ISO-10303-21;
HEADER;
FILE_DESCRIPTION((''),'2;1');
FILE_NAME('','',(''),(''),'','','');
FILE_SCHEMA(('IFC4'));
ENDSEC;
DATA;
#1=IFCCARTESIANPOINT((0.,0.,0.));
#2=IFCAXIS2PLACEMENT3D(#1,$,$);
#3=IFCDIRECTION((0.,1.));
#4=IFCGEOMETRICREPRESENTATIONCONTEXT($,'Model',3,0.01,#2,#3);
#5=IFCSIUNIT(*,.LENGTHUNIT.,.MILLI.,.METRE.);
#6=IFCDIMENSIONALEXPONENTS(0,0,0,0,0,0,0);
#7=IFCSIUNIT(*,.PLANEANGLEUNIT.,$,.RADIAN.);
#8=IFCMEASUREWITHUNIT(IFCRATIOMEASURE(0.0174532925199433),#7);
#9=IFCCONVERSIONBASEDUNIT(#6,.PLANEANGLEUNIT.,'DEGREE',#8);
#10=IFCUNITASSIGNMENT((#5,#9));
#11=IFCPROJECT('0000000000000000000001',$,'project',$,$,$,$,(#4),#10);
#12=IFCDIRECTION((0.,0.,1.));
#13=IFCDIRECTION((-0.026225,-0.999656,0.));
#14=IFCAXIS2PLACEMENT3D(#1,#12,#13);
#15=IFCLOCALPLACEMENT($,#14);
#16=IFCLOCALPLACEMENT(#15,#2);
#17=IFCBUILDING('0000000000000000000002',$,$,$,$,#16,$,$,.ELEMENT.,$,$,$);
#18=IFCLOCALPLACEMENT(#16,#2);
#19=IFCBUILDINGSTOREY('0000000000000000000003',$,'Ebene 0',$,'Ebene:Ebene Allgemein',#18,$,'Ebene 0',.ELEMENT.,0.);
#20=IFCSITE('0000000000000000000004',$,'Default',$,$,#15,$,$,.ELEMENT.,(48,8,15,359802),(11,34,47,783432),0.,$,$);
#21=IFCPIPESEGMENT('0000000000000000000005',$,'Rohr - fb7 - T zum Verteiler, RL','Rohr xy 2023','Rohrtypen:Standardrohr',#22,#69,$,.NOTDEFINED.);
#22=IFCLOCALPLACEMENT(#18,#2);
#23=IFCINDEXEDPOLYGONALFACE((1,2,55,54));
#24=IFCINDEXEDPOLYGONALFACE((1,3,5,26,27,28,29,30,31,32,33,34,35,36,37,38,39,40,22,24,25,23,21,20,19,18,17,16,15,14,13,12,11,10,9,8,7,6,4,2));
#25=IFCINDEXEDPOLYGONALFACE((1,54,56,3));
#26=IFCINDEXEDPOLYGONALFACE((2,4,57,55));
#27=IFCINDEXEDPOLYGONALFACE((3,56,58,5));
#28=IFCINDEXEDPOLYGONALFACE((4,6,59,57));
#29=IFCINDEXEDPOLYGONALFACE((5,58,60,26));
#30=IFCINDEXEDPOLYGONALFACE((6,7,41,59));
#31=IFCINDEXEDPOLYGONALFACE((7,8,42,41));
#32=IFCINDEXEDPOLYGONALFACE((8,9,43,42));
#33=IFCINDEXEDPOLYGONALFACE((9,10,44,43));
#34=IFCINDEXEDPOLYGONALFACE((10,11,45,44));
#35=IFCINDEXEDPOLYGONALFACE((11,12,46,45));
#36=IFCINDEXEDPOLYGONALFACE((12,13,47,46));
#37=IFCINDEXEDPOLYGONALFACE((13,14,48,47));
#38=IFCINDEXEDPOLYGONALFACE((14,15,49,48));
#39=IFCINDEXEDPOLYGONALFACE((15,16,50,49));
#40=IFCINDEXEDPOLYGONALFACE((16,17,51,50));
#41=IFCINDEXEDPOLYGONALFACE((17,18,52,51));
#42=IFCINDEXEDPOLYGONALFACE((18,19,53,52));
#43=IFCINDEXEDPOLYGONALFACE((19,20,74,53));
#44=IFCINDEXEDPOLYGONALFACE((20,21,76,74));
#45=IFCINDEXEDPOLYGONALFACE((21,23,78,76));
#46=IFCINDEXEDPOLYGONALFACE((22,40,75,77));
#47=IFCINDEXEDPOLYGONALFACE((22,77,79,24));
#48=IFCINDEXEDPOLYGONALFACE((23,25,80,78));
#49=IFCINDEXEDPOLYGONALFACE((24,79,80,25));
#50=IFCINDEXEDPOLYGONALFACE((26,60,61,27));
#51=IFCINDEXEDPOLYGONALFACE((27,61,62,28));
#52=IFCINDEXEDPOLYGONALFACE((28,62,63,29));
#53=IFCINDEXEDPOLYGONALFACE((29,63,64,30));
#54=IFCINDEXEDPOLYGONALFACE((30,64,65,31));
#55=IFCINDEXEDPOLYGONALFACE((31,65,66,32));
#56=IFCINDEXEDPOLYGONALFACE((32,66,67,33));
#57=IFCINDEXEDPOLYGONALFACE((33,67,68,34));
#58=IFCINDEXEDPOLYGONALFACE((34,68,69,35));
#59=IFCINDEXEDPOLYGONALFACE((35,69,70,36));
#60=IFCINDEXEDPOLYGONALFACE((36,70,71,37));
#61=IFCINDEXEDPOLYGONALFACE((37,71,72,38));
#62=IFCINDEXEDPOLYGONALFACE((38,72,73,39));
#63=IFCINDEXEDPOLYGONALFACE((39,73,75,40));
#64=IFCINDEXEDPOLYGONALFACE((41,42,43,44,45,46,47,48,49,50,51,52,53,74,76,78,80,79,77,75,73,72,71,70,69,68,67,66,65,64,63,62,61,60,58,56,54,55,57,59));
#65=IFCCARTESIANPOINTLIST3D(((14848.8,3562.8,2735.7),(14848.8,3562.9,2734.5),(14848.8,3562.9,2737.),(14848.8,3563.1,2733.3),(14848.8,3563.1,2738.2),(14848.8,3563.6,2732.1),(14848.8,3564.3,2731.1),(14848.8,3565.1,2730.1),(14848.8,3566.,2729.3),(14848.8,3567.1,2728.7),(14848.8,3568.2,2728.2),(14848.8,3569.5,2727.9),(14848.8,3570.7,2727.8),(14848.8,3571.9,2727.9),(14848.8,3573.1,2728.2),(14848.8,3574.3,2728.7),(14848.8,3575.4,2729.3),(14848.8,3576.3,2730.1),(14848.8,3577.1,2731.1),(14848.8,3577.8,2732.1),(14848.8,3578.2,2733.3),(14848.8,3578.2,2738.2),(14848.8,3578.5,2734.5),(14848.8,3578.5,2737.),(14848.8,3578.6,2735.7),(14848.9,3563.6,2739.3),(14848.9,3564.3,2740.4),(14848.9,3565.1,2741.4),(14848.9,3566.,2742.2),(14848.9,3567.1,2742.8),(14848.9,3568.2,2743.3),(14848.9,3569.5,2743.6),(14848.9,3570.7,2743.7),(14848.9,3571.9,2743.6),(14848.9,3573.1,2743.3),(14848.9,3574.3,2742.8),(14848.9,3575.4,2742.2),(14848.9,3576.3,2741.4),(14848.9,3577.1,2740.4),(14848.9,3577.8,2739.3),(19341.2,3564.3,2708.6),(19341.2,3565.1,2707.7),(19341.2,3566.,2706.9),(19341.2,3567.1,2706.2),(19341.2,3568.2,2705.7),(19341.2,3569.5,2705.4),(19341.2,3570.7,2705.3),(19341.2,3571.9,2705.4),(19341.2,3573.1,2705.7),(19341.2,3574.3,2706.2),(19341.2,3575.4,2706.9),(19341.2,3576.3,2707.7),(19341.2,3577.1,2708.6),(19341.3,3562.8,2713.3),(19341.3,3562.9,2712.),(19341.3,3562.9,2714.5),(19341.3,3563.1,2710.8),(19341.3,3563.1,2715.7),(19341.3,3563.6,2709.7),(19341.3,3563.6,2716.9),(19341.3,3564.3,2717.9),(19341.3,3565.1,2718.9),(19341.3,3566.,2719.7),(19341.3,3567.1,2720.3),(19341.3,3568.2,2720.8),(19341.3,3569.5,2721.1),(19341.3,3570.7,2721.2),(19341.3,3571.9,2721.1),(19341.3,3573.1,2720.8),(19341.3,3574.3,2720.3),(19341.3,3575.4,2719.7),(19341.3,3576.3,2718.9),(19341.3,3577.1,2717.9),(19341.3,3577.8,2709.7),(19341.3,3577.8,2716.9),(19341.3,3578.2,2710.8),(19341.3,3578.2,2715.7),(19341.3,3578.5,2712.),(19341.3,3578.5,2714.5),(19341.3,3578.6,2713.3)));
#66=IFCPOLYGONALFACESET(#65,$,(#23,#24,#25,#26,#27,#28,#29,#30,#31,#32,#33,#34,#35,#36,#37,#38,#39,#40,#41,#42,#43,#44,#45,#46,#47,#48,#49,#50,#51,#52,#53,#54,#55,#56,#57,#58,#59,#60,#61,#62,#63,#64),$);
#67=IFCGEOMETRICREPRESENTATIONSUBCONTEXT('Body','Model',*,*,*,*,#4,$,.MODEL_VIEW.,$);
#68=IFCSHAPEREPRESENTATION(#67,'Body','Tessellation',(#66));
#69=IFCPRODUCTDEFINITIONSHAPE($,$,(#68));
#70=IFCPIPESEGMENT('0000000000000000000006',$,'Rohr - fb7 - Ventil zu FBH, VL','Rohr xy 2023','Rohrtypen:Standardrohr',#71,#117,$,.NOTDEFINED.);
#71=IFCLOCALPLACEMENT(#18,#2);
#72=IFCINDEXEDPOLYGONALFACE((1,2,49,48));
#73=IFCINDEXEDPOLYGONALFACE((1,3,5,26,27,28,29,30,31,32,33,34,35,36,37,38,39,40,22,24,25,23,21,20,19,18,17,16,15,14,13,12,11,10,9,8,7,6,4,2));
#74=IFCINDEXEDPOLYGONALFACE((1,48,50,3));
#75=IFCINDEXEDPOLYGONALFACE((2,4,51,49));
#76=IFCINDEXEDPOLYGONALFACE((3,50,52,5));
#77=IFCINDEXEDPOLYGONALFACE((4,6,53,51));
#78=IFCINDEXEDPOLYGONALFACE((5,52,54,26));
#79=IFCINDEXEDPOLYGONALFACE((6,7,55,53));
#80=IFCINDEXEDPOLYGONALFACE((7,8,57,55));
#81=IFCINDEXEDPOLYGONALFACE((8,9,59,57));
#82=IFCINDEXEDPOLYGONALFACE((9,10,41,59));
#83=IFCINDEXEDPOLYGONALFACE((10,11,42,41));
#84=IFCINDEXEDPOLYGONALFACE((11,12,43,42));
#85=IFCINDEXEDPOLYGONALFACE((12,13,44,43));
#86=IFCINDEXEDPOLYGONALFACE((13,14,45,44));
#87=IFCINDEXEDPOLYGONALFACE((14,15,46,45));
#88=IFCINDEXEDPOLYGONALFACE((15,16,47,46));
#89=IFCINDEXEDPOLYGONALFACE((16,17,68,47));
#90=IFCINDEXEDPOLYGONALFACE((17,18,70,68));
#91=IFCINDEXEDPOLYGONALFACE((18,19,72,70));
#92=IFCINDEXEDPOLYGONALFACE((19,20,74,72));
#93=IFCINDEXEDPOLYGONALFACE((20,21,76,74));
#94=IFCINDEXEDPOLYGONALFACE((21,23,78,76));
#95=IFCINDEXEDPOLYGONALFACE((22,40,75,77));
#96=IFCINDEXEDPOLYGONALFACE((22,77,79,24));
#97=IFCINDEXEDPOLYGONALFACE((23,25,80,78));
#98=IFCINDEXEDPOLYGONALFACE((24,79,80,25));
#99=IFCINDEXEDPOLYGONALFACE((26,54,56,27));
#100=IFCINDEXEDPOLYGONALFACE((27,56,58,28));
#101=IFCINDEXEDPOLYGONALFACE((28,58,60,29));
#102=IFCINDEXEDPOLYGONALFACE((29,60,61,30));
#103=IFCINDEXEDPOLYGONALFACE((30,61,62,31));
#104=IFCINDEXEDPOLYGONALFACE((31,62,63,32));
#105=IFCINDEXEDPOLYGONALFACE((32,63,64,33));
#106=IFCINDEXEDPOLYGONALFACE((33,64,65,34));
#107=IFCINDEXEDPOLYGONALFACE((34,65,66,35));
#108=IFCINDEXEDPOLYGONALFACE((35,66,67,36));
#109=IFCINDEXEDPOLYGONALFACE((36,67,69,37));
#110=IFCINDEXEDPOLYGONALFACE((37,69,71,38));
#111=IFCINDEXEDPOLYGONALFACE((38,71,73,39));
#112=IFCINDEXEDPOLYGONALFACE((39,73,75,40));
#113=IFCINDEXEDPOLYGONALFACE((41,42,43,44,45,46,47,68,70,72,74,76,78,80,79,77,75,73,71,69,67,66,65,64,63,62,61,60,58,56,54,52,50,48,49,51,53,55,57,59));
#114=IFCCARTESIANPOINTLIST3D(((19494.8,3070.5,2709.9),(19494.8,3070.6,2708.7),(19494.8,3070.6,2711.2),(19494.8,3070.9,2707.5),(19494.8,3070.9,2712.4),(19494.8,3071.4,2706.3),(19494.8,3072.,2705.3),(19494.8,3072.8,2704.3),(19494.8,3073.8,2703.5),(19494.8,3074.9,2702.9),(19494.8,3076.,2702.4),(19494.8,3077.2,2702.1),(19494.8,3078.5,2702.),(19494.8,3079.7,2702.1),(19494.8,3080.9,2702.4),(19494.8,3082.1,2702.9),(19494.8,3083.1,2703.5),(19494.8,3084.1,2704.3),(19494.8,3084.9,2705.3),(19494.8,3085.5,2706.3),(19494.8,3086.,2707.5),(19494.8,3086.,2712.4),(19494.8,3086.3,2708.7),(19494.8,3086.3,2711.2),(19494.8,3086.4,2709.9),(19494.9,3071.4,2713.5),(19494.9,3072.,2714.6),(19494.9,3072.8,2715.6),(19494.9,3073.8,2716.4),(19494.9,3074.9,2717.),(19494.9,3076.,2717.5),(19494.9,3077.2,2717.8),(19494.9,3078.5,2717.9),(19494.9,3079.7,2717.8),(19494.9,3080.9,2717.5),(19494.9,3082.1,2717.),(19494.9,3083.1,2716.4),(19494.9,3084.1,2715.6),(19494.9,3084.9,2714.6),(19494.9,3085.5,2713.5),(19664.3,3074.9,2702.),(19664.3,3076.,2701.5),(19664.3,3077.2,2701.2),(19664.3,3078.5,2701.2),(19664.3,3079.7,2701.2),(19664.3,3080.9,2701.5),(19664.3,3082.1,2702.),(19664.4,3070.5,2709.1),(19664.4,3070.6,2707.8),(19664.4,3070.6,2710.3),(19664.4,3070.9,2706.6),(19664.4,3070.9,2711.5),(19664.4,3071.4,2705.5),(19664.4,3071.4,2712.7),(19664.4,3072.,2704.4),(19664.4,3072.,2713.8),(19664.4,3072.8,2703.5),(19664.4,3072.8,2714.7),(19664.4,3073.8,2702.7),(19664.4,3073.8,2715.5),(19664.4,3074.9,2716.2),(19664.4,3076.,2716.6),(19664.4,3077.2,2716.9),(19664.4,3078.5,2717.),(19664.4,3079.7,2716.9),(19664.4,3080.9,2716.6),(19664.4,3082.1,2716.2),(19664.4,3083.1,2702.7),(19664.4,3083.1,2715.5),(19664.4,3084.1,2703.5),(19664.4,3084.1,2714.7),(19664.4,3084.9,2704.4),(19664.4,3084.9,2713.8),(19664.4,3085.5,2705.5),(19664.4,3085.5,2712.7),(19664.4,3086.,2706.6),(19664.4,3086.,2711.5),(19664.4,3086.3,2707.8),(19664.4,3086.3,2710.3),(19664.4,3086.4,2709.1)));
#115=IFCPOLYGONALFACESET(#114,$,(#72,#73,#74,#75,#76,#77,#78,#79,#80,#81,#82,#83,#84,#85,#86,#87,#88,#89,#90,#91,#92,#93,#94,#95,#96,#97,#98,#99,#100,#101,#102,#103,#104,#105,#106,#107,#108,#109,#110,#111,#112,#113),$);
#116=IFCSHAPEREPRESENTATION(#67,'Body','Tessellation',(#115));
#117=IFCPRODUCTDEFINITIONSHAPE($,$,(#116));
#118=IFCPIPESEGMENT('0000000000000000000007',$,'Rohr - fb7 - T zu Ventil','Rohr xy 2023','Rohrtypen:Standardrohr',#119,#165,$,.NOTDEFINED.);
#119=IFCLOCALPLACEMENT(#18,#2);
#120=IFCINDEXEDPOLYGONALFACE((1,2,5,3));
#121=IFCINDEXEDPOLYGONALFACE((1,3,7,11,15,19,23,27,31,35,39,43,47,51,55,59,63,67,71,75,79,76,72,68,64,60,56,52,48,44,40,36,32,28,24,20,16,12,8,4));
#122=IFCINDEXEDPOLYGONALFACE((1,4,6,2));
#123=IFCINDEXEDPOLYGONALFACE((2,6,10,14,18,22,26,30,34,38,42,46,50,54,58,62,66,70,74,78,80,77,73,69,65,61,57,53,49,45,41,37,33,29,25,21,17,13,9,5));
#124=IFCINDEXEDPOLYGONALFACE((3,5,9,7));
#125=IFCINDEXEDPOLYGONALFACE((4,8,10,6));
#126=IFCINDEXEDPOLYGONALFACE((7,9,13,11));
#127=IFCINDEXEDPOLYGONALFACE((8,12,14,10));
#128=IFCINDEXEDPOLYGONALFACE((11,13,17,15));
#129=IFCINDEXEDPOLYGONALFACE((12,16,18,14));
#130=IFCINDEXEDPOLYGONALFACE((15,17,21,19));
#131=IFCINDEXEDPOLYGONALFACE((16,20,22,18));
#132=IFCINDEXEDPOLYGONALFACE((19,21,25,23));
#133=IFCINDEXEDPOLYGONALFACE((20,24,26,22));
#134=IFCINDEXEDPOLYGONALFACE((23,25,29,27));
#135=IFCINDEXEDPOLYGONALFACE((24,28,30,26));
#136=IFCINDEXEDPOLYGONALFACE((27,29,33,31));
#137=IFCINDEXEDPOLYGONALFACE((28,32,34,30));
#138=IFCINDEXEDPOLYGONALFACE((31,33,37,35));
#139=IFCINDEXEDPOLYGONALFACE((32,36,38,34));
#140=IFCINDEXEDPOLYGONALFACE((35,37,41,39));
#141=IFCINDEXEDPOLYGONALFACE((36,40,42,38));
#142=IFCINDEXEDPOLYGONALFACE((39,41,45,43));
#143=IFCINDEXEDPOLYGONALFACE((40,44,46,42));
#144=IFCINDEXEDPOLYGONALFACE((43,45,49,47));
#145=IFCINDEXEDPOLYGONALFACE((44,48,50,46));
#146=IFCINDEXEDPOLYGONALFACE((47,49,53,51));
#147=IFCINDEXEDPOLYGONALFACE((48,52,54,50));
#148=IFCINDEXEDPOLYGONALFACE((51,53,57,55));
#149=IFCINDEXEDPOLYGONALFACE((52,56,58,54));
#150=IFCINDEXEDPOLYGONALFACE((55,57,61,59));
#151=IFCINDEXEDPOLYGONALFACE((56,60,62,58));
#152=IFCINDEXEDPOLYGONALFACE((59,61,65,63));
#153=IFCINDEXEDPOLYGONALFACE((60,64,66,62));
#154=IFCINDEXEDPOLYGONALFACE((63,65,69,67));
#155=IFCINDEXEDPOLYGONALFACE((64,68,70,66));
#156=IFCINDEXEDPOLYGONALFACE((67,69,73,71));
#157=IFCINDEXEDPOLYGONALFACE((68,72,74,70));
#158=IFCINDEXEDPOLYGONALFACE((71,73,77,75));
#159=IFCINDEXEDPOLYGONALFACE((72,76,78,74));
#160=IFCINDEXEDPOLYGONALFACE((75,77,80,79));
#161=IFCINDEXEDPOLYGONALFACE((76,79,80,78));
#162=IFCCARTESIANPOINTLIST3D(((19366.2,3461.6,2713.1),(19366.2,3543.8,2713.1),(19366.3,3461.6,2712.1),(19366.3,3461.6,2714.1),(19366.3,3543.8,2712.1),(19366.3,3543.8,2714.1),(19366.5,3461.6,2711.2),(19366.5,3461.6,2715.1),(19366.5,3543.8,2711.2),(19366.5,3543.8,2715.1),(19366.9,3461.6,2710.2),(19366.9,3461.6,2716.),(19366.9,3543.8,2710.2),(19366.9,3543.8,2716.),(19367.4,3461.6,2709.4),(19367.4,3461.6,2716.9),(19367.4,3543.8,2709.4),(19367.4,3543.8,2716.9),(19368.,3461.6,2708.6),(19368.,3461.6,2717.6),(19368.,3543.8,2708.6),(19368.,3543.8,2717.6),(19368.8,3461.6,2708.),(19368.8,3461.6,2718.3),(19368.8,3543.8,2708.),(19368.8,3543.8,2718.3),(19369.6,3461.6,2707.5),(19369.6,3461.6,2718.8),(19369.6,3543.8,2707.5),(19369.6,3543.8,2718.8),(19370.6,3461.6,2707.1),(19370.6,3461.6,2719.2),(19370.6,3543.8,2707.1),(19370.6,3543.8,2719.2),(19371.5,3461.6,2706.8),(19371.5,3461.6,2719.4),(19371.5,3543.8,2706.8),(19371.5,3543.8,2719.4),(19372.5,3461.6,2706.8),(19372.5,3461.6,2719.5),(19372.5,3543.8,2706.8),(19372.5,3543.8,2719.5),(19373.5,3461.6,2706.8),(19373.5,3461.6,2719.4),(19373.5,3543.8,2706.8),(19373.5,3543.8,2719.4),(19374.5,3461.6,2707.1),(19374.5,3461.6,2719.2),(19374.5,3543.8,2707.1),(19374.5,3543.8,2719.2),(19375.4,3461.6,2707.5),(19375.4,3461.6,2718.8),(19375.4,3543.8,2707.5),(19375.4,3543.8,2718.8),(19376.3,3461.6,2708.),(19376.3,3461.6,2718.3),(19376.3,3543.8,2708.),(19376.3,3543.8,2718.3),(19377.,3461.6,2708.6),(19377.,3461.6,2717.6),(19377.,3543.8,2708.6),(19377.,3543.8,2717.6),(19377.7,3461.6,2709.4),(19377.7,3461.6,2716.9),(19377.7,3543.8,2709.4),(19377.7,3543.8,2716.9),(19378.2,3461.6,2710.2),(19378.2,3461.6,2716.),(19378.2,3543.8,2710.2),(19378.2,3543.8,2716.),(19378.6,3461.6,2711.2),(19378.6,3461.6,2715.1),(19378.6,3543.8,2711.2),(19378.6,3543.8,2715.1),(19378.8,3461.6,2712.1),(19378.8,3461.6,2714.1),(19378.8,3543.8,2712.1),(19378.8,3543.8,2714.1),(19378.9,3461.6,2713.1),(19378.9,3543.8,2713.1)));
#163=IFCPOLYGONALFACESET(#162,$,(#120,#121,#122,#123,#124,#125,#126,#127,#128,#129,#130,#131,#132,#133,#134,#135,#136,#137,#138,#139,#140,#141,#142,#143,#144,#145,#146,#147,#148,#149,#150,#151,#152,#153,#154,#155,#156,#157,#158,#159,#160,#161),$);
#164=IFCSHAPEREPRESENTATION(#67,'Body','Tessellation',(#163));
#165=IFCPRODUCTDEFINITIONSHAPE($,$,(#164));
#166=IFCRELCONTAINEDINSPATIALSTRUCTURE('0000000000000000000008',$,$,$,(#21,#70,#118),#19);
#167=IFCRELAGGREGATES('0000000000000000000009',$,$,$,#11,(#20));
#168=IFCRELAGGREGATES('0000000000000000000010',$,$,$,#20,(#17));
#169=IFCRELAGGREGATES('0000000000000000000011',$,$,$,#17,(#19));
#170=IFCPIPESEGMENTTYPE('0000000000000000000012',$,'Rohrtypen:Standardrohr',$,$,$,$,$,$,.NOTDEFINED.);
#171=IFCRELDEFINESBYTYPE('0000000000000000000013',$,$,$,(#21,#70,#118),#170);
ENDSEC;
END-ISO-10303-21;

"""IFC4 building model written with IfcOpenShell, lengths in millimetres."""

from ifc_helpers import new_model, entity, si_unit, converted_unit, direction, frame, origin, place, context, subcontext, project, spatial, indexed_curve, outline, extrude, type_object, element, save


model = new_model("IFC4")

# Units and contexts
model_context = context("Model", 3, precision=0.01, world=origin(), true_north=direction((0.0, 1.0)))
body_context = subcontext(model_context, "Body", "Model", "MODEL_VIEW")
ifc_project = project(units=[si_unit("LENGTHUNIT", "METRE", prefix="MILLI"), converted_unit("PLANEANGLEUNIT", "DEGREE", entity("IfcRatioMeasure", 0.0174532925199433), si_unit("PLANEANGLEUNIT", "RADIAN"), dimensions=[0, 0, 0, 0, 0, 0, 0])], contexts=[model_context])

# Site, building, storey
site_placement = place(None, frame((0.0, 0.0, 0.0), z_axis=(0.0, 0.0, 1.0), x_axis=(-0.026225, -0.999656, 0.0)))
site = spatial("IfcSite", under=ifc_project, at=site_placement, Name="Default", CompositionType="ELEMENT", RefLatitude=(48, 8, 15, 359802), RefLongitude=(11, 34, 47, 783432), RefElevation=0.0)
building_placement = place(site_placement, origin())
building = spatial("IfcBuilding", under=site, at=building_placement, CompositionType="ELEMENT")
storey_placement = place(building_placement, origin())
storey = spatial("IfcBuildingStorey", under=building, at=storey_placement, Name="Ebene 0", ObjectType="Ebene:Ebene Allgemein", LongName="Ebene 0", CompositionType="ELEMENT", Elevation=0.0)

# Pipe segments
pipe_segment_type = type_object("IfcPipeSegmentType", Name="Rohrtypen:Standardrohr", PredefinedType="NOTDEFINED")
pipe_segment_1_placement = place(storey_placement, origin())
element("IfcPipeSegment", 1, at=pipe_segment_1_placement, inside=storey, type_object=pipe_segment_type, Name="Rohr - fb7 - T zum Verteiler, RL", Description="Rohr xy 2023", ObjectType="Rohrtypen:Standardrohr", PredefinedType="NOTDEFINED", context=body_context, shape_type="SweptSolid", body=[
    extrude(outline(indexed_curve([(7.9, 0.0), (7.8, 1.2), (7.6, 2.5), (7.1, 3.6), (6.4, 4.7), (5.6, 5.6), (4.7, 6.4), (3.6, 7.1), (2.5, 7.6), (1.2, 7.8), (0.0, 7.9), (-1.2, 7.8), (-2.5, 7.6), (-3.6, 7.1), (-4.7, 6.4), (-5.6, 5.6), (-6.4, 4.7), (-7.1, 3.6), (-7.6, 2.5), (-7.8, 1.2), (-7.9, 0.0), (-7.8, -1.2), (-7.6, -2.5), (-7.1, -3.6), (-6.4, -4.7), (-5.6, -5.6), (-4.7, -6.4), (-3.6, -7.1), (-2.5, -7.6), (-1.2, -7.8), (0.0, -7.9), (1.2, -7.8), (2.5, -7.6), (3.6, -7.1), (4.7, -6.4), (5.6, -5.6), (6.4, -4.7), (7.1, -3.6), (7.6, -2.5), (7.8, -1.2), (7.9, 0.0)], self_intersect=False)), frame((14848.8, 3570.7, 2735.7), z_axis=(0.999988, 0.0, -0.005), x_axis=(0.0, 1.0, 0.0)), (0.0, 0.0, 1.0), 4492.5),
])
pipe_segment_2_placement = place(storey_placement, origin())
element("IfcPipeSegment", 2, at=pipe_segment_2_placement, inside=storey, type_object=pipe_segment_type, Name="Rohr - fb7 - Ventil zu FBH, VL", Description="Rohr xy 2023", ObjectType="Rohrtypen:Standardrohr", PredefinedType="NOTDEFINED", context=body_context, shape_type="SweptSolid", body=[
    extrude(outline(indexed_curve([(7.9, 0.0), (7.8, 1.2), (7.6, 2.5), (7.1, 3.6), (6.4, 4.7), (5.6, 5.6), (4.7, 6.4), (3.6, 7.1), (2.5, 7.6), (1.2, 7.8), (0.0, 7.9), (-1.2, 7.8), (-2.5, 7.6), (-3.6, 7.1), (-4.7, 6.4), (-5.6, 5.6), (-6.4, 4.7), (-7.1, 3.6), (-7.6, 2.5), (-7.8, 1.2), (-7.9, 0.0), (-7.8, -1.2), (-7.6, -2.5), (-7.1, -3.6), (-6.4, -4.7), (-5.6, -5.6), (-4.7, -6.4), (-3.6, -7.1), (-2.5, -7.6), (-1.2, -7.8), (0.0, -7.9), (1.2, -7.8), (2.5, -7.6), (3.6, -7.1), (4.7, -6.4), (5.6, -5.6), (6.4, -4.7), (7.1, -3.6), (7.6, -2.5), (7.8, -1.2), (7.9, 0.0)], self_intersect=False)), frame((19494.8, 3078.5, 2709.9), z_axis=(0.999988, 0.0, -0.005), x_axis=(0.0, 1.0, 0.0)), (0.0, 0.0, 1.0), 169.5),
])
pipe_segment_3_placement = place(storey_placement, origin())
element("IfcPipeSegment", 3, at=pipe_segment_3_placement, inside=storey, type_object=pipe_segment_type, Name="Rohr - fb7 - T zu Ventil", Description="Rohr xy 2023", ObjectType="Rohrtypen:Standardrohr", PredefinedType="NOTDEFINED", context=body_context, shape_type="SweptSolid", body=[
    extrude(outline(indexed_curve([(6.4, 0.0), (6.3, 1.0), (6.0, 2.0), (5.7, 2.9), (5.1, 3.7), (4.5, 4.5), (3.7, 5.1), (2.9, 5.7), (2.0, 6.0), (1.0, 6.3), (0.0, 6.4), (-1.0, 6.3), (-2.0, 6.0), (-2.9, 5.7), (-3.7, 5.1), (-4.5, 4.5), (-5.1, 3.7), (-5.7, 2.9), (-6.0, 2.0), (-6.3, 1.0), (-6.3, 0.0), (-6.3, -1.0), (-6.0, -2.0), (-5.7, -2.9), (-5.1, -3.7), (-4.5, -4.5), (-3.7, -5.1), (-2.9, -5.7), (-2.0, -6.0), (-1.0, -6.3), (0.0, -6.4), (1.0, -6.3), (2.0, -6.0), (2.9, -5.7), (3.7, -5.1), (4.5, -4.5), (5.1, -3.7), (5.7, -2.9), (6.0, -2.0), (6.3, -1.0), (6.4, 0.0)], self_intersect=False)), frame((19372.5, 3461.6, 2713.1), z_axis=(0.0, 1.0, 0.0), x_axis=(-1.0, 0.0, 0.0)), (0.0, 0.0, 1.0), 82.2),
])

save(model, "model.ifc")
